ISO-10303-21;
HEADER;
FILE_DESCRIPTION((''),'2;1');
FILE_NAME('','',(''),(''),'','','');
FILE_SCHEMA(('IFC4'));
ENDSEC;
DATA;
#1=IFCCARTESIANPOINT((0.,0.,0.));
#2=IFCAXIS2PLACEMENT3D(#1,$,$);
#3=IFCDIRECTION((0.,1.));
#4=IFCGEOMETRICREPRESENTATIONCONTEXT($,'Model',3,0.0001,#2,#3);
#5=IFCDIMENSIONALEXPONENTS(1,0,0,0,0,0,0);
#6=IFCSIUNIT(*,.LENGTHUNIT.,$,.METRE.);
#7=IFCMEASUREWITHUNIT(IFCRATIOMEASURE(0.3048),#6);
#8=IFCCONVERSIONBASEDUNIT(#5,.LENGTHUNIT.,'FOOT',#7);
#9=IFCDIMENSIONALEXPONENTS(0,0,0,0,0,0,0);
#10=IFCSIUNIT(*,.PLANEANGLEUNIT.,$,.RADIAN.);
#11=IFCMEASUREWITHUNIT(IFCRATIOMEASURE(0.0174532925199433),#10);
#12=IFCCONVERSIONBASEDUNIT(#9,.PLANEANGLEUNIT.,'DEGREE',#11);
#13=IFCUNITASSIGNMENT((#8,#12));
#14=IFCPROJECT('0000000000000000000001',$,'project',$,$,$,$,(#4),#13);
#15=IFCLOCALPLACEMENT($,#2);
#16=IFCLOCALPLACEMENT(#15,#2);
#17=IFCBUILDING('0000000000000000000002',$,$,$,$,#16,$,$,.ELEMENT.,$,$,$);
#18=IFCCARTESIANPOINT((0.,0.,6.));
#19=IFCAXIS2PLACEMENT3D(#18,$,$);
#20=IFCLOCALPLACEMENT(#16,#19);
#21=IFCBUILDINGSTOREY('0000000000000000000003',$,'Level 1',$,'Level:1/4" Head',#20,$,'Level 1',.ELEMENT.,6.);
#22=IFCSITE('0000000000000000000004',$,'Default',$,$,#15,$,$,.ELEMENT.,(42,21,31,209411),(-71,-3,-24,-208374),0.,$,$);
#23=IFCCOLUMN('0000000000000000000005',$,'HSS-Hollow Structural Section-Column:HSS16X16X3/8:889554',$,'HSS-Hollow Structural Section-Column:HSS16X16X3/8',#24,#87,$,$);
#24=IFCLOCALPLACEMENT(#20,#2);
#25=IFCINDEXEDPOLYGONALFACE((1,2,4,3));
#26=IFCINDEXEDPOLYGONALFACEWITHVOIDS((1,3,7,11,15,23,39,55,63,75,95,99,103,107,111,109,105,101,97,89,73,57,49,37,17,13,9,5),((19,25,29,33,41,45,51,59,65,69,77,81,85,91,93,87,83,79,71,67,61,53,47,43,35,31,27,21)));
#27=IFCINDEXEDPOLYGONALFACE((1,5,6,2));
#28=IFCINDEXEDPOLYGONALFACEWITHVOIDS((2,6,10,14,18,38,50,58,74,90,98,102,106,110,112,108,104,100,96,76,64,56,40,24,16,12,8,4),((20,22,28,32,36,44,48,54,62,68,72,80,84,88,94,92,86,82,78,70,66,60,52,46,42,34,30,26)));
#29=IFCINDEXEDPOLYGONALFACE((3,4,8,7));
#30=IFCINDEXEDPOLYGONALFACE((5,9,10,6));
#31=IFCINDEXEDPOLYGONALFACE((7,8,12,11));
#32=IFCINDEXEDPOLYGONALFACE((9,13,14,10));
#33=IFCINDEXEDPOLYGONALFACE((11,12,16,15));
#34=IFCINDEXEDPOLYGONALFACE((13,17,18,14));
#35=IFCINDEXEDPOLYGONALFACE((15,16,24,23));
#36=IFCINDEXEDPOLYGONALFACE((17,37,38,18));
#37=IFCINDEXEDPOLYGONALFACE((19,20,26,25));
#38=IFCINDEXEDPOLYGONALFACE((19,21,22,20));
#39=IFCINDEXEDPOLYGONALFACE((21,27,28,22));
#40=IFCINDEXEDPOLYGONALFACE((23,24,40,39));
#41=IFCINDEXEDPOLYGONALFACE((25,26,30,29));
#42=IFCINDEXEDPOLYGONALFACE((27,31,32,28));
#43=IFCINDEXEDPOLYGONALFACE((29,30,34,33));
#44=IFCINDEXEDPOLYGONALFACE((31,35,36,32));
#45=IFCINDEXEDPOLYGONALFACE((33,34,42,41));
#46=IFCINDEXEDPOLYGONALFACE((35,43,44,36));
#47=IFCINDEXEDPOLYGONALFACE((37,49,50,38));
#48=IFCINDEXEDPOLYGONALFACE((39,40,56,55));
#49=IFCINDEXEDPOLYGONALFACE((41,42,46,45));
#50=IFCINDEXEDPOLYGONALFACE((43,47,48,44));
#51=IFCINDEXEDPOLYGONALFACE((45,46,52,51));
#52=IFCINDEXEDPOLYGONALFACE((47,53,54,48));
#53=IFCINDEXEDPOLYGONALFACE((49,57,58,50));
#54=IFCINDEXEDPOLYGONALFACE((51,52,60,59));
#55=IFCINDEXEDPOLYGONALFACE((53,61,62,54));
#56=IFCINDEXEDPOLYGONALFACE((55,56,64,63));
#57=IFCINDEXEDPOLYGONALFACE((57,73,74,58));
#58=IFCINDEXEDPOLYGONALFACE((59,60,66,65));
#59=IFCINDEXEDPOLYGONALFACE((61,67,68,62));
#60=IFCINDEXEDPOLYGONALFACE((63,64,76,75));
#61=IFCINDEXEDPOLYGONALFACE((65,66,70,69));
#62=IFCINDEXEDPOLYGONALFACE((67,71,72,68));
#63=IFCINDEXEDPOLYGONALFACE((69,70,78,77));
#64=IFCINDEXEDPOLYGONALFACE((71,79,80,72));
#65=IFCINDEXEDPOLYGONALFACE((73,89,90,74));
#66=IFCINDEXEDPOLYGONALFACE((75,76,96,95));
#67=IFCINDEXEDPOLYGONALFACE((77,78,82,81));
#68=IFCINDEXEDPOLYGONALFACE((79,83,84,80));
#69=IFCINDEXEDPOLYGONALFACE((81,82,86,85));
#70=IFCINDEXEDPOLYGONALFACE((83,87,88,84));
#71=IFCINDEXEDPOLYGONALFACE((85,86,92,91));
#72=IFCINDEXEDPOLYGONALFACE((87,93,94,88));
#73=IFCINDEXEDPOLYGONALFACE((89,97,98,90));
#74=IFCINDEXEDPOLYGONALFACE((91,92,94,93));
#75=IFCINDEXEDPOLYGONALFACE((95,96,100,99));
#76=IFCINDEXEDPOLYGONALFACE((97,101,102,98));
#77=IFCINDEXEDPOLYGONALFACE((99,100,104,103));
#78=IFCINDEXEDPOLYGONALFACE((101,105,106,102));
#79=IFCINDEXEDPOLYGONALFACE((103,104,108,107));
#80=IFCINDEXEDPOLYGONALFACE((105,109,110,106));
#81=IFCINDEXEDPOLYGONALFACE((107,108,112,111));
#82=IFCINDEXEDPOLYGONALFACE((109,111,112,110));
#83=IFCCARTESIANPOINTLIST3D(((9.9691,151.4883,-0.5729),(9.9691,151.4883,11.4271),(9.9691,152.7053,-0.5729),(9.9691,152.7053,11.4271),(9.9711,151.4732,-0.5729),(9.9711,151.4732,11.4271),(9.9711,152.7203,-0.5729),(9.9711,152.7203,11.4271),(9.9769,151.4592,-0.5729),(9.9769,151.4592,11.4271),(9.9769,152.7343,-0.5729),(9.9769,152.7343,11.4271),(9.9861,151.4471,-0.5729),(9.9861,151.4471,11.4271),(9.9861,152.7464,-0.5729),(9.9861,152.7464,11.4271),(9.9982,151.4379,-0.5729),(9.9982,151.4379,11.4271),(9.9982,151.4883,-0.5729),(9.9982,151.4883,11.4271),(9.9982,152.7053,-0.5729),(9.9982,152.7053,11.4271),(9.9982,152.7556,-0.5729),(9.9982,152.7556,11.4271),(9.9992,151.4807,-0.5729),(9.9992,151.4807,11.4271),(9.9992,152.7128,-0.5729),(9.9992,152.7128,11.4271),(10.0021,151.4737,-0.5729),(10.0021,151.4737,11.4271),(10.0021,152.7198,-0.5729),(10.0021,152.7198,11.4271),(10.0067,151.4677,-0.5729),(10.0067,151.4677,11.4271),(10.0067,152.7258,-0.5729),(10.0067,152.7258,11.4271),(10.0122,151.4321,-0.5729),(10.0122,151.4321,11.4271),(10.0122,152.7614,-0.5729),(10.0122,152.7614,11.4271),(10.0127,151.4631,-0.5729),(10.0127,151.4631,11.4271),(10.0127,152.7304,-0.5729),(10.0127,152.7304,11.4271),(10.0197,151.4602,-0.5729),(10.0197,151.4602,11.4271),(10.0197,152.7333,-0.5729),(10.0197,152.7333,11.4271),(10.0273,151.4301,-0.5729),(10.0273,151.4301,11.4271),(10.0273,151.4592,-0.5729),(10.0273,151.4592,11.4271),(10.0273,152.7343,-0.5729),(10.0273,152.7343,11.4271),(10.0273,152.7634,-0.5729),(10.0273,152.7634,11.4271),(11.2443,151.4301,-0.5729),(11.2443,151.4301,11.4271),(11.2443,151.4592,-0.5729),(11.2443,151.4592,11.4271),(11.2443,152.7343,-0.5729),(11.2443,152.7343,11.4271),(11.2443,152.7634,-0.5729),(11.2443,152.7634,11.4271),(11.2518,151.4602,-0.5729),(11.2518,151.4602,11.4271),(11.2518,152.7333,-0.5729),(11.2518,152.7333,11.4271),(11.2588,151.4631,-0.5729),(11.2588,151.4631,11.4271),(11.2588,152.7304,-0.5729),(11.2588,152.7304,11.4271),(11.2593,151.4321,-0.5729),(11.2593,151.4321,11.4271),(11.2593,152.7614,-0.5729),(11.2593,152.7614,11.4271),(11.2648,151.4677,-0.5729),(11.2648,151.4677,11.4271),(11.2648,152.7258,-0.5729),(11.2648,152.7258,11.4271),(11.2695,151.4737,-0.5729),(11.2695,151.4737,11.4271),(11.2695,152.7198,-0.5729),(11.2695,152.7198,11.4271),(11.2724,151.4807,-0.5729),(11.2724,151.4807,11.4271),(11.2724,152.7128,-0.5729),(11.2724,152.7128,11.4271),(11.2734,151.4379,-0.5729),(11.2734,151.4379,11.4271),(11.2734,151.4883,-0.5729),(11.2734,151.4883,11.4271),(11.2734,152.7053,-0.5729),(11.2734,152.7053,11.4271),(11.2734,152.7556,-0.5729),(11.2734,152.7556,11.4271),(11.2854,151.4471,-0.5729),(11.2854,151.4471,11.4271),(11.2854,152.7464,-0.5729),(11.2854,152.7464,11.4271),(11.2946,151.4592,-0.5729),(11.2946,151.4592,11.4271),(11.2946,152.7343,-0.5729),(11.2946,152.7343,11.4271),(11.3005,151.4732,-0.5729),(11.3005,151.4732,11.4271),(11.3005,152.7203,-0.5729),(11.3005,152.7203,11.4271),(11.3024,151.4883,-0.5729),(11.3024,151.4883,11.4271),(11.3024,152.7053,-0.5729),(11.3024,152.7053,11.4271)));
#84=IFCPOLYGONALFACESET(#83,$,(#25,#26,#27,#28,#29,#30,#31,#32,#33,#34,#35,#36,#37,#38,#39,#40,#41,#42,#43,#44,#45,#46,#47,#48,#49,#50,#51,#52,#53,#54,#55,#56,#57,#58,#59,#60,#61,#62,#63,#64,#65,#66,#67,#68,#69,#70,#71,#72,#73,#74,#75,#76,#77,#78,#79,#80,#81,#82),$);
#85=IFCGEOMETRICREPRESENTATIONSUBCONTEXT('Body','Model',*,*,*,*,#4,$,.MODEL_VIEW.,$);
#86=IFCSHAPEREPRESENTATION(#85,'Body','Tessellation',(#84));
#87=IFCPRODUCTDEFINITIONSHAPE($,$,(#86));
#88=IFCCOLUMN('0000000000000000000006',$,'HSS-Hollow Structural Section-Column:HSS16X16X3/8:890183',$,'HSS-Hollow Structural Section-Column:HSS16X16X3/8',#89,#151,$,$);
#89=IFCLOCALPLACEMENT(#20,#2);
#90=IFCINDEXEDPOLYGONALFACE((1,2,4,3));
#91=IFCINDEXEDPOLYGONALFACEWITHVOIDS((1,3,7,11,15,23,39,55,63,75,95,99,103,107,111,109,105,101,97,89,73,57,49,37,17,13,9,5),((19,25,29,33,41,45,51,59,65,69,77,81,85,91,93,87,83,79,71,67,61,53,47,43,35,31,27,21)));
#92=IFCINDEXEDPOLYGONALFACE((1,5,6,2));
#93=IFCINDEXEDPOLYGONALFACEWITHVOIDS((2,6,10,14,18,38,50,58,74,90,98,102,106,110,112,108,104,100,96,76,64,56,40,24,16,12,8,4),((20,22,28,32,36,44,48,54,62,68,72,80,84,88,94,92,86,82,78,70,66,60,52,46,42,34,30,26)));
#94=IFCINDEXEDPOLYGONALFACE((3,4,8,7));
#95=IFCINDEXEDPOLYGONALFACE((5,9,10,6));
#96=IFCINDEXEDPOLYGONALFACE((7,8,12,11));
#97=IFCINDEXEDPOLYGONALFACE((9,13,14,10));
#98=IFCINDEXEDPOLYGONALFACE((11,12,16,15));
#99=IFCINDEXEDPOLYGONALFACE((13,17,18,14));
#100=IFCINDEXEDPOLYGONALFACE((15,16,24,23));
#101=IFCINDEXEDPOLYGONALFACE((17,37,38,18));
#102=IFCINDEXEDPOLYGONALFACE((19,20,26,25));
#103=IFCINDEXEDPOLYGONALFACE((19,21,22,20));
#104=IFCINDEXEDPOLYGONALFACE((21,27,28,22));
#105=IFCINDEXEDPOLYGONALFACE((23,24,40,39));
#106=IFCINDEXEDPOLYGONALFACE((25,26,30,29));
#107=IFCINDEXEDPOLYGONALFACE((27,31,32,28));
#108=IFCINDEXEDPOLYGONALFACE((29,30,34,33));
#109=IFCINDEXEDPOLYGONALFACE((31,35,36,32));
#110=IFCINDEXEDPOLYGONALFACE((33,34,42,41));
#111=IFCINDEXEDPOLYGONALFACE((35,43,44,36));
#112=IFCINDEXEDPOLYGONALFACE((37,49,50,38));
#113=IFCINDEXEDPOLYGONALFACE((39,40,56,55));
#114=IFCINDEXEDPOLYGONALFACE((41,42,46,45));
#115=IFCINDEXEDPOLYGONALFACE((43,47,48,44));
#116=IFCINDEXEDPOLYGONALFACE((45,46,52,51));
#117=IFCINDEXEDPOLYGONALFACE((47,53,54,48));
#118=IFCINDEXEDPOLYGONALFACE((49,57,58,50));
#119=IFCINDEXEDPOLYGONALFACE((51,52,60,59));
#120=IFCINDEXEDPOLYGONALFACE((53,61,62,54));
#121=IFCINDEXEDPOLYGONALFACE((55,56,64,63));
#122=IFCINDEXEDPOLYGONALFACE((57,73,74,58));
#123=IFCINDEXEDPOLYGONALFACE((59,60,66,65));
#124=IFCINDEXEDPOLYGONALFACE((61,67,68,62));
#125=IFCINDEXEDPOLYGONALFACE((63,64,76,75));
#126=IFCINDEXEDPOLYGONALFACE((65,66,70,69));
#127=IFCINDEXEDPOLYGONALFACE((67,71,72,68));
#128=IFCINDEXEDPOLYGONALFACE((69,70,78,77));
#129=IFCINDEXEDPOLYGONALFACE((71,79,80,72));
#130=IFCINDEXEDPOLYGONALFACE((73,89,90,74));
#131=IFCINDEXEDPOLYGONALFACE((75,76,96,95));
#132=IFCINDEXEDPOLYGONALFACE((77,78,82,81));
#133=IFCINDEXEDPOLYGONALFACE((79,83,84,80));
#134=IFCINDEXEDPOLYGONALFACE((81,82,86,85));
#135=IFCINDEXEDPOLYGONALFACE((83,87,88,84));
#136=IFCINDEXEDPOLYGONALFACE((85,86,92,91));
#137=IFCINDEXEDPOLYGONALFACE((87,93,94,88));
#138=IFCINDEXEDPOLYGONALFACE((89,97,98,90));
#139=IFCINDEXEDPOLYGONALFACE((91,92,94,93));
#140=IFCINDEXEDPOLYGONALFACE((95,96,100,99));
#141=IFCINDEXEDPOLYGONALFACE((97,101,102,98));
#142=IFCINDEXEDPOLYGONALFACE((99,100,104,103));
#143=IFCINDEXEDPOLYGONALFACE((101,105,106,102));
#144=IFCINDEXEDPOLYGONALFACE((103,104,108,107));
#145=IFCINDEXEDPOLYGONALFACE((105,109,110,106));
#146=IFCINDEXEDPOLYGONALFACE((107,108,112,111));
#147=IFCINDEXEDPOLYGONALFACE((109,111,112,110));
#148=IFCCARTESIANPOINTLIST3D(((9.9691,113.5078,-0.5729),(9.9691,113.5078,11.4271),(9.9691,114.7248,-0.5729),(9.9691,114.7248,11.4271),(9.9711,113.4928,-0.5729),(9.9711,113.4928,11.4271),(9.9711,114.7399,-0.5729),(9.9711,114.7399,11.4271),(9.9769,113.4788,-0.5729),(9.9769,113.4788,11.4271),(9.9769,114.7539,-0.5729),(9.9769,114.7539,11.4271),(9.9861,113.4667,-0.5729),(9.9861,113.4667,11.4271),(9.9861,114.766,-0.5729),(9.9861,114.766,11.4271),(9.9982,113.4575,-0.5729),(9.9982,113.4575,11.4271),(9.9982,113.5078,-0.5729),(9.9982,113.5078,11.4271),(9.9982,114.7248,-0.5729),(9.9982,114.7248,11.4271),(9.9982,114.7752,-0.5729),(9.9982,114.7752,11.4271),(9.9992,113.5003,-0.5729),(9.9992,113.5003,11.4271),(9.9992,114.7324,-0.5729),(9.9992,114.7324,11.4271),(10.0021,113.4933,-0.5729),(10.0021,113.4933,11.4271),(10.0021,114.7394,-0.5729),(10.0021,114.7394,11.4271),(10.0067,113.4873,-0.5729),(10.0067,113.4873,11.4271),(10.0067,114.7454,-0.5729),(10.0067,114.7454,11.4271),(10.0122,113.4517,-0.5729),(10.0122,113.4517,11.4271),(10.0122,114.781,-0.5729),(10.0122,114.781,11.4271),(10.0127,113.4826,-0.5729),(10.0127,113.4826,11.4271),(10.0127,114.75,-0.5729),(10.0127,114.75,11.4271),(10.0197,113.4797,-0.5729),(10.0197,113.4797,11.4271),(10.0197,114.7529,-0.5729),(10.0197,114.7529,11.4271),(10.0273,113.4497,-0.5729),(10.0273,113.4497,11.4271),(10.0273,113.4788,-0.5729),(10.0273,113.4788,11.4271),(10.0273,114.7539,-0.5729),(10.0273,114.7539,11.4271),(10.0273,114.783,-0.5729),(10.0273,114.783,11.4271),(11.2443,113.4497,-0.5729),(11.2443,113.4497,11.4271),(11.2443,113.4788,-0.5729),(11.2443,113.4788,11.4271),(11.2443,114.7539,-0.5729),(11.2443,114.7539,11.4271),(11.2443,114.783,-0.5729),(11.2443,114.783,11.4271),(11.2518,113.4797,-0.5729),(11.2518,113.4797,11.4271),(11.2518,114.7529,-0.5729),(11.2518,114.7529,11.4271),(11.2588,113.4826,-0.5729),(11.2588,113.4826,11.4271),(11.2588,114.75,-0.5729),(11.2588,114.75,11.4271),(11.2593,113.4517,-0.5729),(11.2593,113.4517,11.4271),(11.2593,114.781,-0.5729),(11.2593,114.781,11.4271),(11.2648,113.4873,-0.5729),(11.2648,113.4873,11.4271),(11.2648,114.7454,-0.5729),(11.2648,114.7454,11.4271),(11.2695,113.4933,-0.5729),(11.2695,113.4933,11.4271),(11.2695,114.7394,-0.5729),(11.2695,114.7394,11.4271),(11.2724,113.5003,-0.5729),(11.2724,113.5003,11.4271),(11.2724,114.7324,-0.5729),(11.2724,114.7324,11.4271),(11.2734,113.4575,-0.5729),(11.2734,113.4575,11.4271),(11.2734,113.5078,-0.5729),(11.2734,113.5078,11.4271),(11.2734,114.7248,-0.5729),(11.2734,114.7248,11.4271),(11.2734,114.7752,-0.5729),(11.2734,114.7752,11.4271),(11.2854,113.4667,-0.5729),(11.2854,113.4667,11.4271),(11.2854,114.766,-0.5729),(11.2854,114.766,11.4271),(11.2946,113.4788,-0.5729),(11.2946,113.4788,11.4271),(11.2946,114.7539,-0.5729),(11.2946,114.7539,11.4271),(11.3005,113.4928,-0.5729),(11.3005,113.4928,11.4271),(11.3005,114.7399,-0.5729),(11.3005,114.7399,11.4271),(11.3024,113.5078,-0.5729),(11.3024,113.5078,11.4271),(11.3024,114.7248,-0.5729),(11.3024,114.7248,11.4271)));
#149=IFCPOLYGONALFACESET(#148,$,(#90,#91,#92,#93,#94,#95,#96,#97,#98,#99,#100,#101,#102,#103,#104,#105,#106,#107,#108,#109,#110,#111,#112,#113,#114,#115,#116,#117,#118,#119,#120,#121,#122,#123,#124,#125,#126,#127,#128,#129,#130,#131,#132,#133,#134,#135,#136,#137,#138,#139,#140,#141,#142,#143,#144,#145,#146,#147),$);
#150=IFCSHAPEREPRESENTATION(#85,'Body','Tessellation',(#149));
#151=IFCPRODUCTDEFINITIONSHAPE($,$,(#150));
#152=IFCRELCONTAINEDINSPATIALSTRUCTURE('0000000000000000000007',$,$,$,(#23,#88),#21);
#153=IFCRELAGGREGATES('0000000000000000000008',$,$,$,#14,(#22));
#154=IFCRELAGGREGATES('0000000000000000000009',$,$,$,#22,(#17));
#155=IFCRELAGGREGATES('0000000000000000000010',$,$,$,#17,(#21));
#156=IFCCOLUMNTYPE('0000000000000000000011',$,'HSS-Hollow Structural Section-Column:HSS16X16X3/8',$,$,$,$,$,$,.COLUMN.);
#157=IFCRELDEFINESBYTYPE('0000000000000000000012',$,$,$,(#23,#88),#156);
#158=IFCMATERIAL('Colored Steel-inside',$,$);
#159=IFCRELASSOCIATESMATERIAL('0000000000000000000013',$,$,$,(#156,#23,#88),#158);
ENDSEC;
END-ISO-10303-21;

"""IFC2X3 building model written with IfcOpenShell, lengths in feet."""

from ifc_helpers import new_model, entity, si_unit, converted_unit, direction, frame, frame_2d, origin, place, context, subcontext, project, spatial, polyline, circle_curve, parameter, trimmed, segment, composite_curve, outline, extrude, source, transform, mapped, material, type_object, type_shapes, element, save


model = new_model("IFC2X3")

# Units and contexts
model_context = context("Model", 3, precision=0.0001, world=origin(), true_north=direction((0.0, 1.0)))
body_context = subcontext(model_context, "Body", "Model", "MODEL_VIEW")
ifc_project = project(units=[converted_unit("LENGTHUNIT", "FOOT", entity("IfcRatioMeasure", 0.3048), si_unit("LENGTHUNIT", "METRE"), dimensions=[1, 0, 0, 0, 0, 0, 0]), converted_unit("PLANEANGLEUNIT", "DEGREE", entity("IfcRatioMeasure", 0.0174532925199433), si_unit("PLANEANGLEUNIT", "RADIAN"), dimensions=[0, 0, 0, 0, 0, 0, 0])], contexts=[model_context])

# Site, building, storey
site_placement = place(None, origin())
site = spatial("IfcSite", under=ifc_project, at=site_placement, Name="Default", CompositionType="ELEMENT", RefLatitude=(42, 21, 31, 209411), RefLongitude=(-71, -3, -24, -208374), RefElevation=0.0)
building_placement = place(site_placement, origin())
building = spatial("IfcBuilding", under=site, at=building_placement, CompositionType="ELEMENT")
storey_placement = place(building_placement, frame((0.0, 0.0, 6.0)))
storey = spatial("IfcBuildingStorey", under=building, at=storey_placement, Name="Level 1", ObjectType="Level:1/4\" Head", LongName="Level 1", CompositionType="ELEMENT", Elevation=6.0)

# Columns
ifc_material_1 = material(Name="Colored Steel-inside")
column_type_1 = type_object("IfcColumnType", Name="HSS-Hollow Structural Section-Column:HSS16X16X3/8", PredefinedType="COLUMN", material=ifc_material_1)
shared_shape_1 = source(origin(), body_context, "Body", "SweptSolid", [
    extrude(outline(composite_curve([segment(polyline([(-0.6085, -0.6667), (0.6085, -0.6667)]), True, "CONTINUOUS"), segment(trimmed(circle_curve(frame_2d((0.6085, -0.6085), x_axis=(-1.0, 0.0)), 0.0582), [parameter(90.0)], [parameter(180.0)], True, "PARAMETER"), True, "CONTINUOUS"), segment(polyline([(0.6667, -0.6085), (0.6667, 0.6085)]), True, "CONTINUOUS"), segment(trimmed(circle_curve(frame_2d((0.6085, 0.6085), x_axis=(-1.0, 0.0)), 0.0582), [parameter(180.0)], [parameter(270.0)], True, "PARAMETER"), True, "CONTINUOUS"), segment(polyline([(0.6085, 0.6667), (-0.6085, 0.6667)]), True, "CONTINUOUS"), segment(trimmed(circle_curve(frame_2d((-0.6085, 0.6085), x_axis=(-1.0, 0.0)), 0.0582), [parameter(270.0)], [parameter(360.0)], True, "PARAMETER"), True, "CONTINUOUS"), segment(polyline([(-0.6667, 0.6085), (-0.6667, -0.6085)]), True, "CONTINUOUS"), segment(trimmed(circle_curve(frame_2d((-0.6085, -0.6085), x_axis=(-1.0, 0.0)), 0.0582), [parameter(360.0)], [parameter(90.0)], True, "PARAMETER"), True, "CONTINUOUS")], self_intersect=False), holes=[composite_curve([segment(trimmed(circle_curve(frame_2d((-0.6085, -0.6085), x_axis=(-1.0, 0.0)), 0.0291), [parameter(0.0)], [parameter(90.0)], True, "PARAMETER"), False, "CONTINUOUS"), segment(polyline([(-0.6376, -0.6085), (-0.6376, 0.6085)]), True, "CONTINUOUS"), segment(trimmed(circle_curve(frame_2d((-0.6085, 0.6085), x_axis=(-1.0, 0.0)), 0.0291), [parameter(270.0)], [parameter(360.0)], True, "PARAMETER"), False, "CONTINUOUS"), segment(polyline([(-0.6085, 0.6376), (0.6085, 0.6376)]), True, "CONTINUOUS"), segment(trimmed(circle_curve(frame_2d((0.6085, 0.6085), x_axis=(-1.0, 0.0)), 0.0291), [parameter(180.0)], [parameter(270.0)], True, "PARAMETER"), False, "CONTINUOUS"), segment(polyline([(0.6376, 0.6085), (0.6376, -0.6085)]), True, "CONTINUOUS"), segment(trimmed(circle_curve(frame_2d((0.6085, -0.6085), x_axis=(-1.0, 0.0)), 0.0291), [parameter(90.0)], [parameter(180.0)], True, "PARAMETER"), False, "CONTINUOUS"), segment(polyline([(0.6085, -0.6376), (-0.6085, -0.6376)]), True, "CONTINUOUS")], self_intersect=False)]), frame((0.0, 0.0, 5.4271), z_axis=(0.0, 0.0, 1.0), x_axis=(-1.0, 0.0, 0.0)), (0.0, 0.0, 1.0), 12.0),
])
type_shapes(column_type_1, [shared_shape_1])
for number, where, name in (
    (1, (10.6358, 152.0968, -6.0), "HSS-Hollow Structural Section-Column:HSS16X16X3/8:889554"),
    (2, (10.6358, 114.1163, -6.0), "HSS-Hollow Structural Section-Column:HSS16X16X3/8:890183"),
):
    element("IfcColumn", number, at=place(storey_placement, frame(where)), inside=storey, type_object=column_type_1, material=ifc_material_1, Name=name, ObjectType="HSS-Hollow Structural Section-Column:HSS16X16X3/8", context=body_context, shape_type="MappedRepresentation", body=[
        mapped(shared_shape_1, transform((0.0, 0.0, 0.0), scale=1.0)),
    ])

save(model, "model.ifc")
